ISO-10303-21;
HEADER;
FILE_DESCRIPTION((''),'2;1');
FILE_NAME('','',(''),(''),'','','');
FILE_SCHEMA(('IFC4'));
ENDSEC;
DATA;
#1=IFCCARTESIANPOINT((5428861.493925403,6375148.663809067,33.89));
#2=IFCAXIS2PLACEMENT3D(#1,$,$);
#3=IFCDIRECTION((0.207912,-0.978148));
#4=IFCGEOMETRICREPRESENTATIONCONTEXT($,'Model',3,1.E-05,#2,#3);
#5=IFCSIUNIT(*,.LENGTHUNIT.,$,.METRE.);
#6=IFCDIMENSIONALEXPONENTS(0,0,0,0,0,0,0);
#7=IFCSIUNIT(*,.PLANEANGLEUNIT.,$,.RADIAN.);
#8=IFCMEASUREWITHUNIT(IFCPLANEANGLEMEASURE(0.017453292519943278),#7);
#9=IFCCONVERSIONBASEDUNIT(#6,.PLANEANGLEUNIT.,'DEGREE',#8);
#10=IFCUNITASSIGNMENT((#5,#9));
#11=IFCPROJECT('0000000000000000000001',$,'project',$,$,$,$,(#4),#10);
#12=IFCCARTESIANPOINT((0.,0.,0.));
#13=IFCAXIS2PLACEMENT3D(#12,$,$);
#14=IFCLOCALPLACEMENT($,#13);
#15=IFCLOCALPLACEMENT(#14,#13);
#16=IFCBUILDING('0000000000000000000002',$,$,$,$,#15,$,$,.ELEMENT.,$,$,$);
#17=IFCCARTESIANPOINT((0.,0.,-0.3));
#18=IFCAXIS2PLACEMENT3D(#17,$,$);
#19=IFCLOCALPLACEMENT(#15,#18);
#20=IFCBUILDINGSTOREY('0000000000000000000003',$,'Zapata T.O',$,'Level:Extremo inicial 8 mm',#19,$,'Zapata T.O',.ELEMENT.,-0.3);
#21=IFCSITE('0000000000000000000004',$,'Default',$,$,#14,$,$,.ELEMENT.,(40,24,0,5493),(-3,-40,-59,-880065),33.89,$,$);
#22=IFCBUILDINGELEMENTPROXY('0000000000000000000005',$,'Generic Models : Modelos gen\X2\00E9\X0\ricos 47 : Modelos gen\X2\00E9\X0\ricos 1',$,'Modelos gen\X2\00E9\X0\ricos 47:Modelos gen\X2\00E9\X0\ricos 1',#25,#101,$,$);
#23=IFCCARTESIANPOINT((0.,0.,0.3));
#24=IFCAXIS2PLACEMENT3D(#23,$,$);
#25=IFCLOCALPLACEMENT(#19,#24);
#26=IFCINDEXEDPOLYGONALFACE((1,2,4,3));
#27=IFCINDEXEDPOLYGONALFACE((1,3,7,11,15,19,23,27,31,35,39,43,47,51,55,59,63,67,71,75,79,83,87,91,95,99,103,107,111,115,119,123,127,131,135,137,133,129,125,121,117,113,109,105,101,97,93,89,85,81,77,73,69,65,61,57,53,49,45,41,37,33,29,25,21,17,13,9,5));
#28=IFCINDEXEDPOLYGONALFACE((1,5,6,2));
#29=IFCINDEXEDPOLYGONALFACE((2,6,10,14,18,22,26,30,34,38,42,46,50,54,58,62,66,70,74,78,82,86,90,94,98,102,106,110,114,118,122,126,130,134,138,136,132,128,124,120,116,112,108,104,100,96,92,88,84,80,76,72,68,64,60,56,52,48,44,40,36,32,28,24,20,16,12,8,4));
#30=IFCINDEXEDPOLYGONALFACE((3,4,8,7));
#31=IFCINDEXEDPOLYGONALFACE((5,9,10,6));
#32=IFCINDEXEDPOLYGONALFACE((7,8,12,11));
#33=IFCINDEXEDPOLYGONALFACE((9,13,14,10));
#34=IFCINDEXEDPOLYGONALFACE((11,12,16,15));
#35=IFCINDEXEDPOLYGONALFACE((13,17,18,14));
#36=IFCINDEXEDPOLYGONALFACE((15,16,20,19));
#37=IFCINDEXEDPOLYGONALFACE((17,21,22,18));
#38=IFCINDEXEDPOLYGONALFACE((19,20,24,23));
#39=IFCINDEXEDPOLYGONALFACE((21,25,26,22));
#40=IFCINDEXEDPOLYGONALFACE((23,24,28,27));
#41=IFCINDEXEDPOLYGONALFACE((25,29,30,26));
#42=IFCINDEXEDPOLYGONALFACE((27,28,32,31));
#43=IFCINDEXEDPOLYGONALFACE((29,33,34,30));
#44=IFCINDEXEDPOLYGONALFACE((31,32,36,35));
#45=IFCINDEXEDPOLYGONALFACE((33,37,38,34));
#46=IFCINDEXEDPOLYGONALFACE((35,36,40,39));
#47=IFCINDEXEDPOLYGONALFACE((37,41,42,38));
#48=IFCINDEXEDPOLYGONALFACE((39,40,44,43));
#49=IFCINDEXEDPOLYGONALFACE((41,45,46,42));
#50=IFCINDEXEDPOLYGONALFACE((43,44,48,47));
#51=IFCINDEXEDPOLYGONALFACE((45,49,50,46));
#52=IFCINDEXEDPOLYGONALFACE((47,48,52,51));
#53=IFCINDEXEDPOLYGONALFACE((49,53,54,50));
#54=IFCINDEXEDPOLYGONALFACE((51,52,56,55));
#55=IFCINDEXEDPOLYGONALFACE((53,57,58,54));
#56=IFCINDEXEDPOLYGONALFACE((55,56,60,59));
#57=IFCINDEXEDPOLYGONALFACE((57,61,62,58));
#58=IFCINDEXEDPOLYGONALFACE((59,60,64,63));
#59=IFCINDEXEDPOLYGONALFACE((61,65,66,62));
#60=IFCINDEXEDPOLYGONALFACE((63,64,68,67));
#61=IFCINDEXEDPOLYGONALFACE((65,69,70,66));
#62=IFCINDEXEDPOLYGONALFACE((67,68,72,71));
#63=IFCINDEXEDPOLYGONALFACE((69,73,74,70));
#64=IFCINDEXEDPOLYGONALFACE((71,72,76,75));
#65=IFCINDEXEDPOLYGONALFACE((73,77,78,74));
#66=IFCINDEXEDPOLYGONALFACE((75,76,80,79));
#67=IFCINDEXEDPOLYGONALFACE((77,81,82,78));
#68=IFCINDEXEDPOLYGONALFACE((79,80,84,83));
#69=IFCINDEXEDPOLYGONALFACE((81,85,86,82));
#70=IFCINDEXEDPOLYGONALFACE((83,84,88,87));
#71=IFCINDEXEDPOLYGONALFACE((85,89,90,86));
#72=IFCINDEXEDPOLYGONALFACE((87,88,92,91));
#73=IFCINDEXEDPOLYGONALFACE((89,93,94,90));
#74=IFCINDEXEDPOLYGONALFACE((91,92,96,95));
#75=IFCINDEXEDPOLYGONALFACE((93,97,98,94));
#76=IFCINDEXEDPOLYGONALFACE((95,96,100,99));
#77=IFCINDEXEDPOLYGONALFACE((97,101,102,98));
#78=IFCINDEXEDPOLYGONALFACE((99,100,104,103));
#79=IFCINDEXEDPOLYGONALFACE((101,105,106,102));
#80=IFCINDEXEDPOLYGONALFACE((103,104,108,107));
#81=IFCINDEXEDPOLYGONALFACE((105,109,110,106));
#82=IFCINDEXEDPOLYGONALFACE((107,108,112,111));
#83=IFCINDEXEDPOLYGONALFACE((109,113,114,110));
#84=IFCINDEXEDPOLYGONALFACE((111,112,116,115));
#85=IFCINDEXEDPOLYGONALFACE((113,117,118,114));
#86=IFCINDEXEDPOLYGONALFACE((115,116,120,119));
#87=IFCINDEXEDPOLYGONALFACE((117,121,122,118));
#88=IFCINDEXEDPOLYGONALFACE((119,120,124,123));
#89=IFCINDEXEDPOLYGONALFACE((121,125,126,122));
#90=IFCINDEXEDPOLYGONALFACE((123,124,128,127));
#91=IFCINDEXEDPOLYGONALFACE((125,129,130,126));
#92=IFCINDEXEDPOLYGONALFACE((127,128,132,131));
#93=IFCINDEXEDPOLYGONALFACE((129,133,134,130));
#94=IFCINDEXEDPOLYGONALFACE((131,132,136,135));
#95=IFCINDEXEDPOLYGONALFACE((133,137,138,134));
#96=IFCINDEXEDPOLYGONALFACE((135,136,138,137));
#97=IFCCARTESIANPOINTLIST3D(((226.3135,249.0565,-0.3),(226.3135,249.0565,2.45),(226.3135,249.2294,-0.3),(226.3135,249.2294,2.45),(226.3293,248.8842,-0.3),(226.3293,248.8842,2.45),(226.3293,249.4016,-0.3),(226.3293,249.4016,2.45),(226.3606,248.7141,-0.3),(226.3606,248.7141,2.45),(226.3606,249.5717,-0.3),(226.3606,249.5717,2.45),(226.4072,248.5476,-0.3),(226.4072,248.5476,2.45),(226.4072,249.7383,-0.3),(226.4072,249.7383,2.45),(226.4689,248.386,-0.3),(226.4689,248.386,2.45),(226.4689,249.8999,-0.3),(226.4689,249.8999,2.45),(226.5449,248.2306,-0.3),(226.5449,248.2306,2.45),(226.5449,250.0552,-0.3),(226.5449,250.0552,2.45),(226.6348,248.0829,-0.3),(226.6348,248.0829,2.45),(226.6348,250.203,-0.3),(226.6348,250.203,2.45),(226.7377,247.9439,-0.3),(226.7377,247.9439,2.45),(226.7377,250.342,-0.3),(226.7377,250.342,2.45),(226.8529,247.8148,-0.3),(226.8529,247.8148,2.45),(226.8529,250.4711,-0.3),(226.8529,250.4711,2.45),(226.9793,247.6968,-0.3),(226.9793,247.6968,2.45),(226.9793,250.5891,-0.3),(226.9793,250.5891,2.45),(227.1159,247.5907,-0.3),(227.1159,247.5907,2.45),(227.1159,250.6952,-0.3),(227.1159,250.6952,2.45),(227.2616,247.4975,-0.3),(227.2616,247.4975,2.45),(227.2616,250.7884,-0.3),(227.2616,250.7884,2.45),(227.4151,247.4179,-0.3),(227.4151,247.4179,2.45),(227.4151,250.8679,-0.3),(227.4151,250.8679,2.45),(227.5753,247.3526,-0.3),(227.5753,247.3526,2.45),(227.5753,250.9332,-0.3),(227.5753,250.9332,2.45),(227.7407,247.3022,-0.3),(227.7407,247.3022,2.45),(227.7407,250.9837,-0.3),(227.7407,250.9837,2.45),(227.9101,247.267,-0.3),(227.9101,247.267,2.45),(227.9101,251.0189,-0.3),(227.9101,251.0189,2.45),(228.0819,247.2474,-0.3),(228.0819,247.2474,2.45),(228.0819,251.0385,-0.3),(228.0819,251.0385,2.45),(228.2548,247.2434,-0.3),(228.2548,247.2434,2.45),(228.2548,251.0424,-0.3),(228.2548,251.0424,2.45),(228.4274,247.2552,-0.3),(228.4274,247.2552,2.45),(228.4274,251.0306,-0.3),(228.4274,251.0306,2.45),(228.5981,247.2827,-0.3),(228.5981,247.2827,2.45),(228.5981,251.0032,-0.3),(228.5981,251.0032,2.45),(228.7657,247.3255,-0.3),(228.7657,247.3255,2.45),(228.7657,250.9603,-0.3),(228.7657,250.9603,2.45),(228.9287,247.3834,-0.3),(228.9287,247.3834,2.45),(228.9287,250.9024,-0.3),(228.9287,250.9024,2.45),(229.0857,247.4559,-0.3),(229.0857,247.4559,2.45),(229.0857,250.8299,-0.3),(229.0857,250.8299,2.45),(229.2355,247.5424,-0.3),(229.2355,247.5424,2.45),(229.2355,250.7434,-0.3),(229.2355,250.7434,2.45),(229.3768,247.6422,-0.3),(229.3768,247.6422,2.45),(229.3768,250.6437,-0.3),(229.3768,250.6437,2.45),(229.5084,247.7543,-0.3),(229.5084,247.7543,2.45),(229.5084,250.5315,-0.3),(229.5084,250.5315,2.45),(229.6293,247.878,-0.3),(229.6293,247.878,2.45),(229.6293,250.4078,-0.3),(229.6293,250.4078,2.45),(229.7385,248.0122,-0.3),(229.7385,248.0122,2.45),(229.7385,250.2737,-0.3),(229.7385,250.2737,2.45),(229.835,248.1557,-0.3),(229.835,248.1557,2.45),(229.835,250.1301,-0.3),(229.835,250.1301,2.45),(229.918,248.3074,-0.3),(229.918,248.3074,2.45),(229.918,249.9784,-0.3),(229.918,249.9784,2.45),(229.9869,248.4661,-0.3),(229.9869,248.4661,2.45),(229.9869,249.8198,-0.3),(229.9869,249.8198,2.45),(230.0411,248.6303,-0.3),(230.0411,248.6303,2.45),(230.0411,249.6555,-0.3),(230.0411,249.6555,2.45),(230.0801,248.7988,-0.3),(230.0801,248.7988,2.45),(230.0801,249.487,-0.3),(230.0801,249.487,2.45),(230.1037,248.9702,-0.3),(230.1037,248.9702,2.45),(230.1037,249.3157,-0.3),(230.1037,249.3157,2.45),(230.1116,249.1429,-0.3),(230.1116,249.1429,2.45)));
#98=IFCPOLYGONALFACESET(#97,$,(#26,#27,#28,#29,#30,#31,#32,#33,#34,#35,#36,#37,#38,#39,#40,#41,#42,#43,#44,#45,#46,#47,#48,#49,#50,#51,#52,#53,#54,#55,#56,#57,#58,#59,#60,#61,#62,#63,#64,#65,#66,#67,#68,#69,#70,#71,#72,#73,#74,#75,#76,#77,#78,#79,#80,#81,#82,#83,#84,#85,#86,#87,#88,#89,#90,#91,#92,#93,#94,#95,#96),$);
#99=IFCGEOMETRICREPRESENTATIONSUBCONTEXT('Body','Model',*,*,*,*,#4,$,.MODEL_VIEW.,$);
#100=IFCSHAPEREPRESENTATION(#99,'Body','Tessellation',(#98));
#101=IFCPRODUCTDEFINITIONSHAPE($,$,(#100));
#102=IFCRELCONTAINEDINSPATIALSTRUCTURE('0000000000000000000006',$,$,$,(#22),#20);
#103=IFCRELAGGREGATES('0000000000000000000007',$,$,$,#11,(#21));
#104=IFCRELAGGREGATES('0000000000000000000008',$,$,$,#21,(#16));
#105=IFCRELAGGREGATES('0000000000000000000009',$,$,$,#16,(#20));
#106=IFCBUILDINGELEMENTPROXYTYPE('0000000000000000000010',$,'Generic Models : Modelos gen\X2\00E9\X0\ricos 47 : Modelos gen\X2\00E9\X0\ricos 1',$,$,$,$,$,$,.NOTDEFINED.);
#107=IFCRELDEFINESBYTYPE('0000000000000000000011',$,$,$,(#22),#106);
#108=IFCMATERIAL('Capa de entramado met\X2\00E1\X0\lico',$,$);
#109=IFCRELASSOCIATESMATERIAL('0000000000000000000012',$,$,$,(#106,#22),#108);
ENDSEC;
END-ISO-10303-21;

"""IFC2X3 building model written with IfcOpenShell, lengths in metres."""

from ifc_helpers import new_model, entity, si_unit, converted_unit, direction, frame, origin, origin_2d_with_axis, place, context, subcontext, project, spatial, circle, extrude, source, transform, mapped, material, type_object, type_shapes, element, save


model = new_model("IFC2X3")

# Units and contexts
model_context = context("Model", 3, precision=1e-05, world=frame((5428861.493925403, 6375148.663809067, 33.89)), true_north=direction((0.207912, -0.978148)))
body_context = subcontext(model_context, "Body", "Model", "MODEL_VIEW")
ifc_project = project(units=[si_unit("LENGTHUNIT", "METRE"), converted_unit("PLANEANGLEUNIT", "DEGREE", entity("IfcPlaneAngleMeasure", 0.017453292519943278), si_unit("PLANEANGLEUNIT", "RADIAN"), dimensions=[0, 0, 0, 0, 0, 0, 0])], contexts=[model_context])

# Site, building, storey
site_placement = place(None, origin())
site = spatial("IfcSite", under=ifc_project, at=site_placement, Name="Default", CompositionType="ELEMENT", RefLatitude=(40, 24, 0, 5493), RefLongitude=(-3, -40, -59, -880065), RefElevation=33.89)
building_placement = place(site_placement, origin())
building = spatial("IfcBuilding", under=site, at=building_placement, CompositionType="ELEMENT")
storey_placement = place(building_placement, frame((0.0, 0.0, -0.3)))
storey = spatial("IfcBuildingStorey", under=building, at=storey_placement, Name="Zapata T.O", ObjectType="Level:Extremo inicial 8 mm", LongName="Zapata T.O", CompositionType="ELEMENT", Elevation=-0.3)

# Building element proxy
ifc_material = material(Name="Capa de entramado metálico")
building_element_proxy_type_1 = type_object("IfcBuildingElementProxyType", Name="Generic Models : Modelos genéricos 47 : Modelos genéricos 1", PredefinedType="NOTDEFINED", material=ifc_material)
shared_shape_1 = source(origin(), body_context, "Body", "SweptSolid", [
    extrude(circle(Radius=1.9, at=origin_2d_with_axis()), frame((228.2116, 249.1429, -0.3)), (0.0, 0.0, 1.0), 2.75),
])
type_shapes(building_element_proxy_type_1, [shared_shape_1])
proxy_1_placement = place(storey_placement, frame((0.0, 0.0, 0.3)))
element("IfcBuildingElementProxy", 1, at=proxy_1_placement, inside=storey, type_object=building_element_proxy_type_1, material=ifc_material, Name="Generic Models : Modelos genéricos 47 : Modelos genéricos 1", ObjectType="Modelos genéricos 47:Modelos genéricos 1", context=body_context, shape_type="MappedRepresentation", body=[
    mapped(shared_shape_1, transform((0.0, 0.0, 0.0), scale=1.0)),
])

save(model, "model.ifc")
